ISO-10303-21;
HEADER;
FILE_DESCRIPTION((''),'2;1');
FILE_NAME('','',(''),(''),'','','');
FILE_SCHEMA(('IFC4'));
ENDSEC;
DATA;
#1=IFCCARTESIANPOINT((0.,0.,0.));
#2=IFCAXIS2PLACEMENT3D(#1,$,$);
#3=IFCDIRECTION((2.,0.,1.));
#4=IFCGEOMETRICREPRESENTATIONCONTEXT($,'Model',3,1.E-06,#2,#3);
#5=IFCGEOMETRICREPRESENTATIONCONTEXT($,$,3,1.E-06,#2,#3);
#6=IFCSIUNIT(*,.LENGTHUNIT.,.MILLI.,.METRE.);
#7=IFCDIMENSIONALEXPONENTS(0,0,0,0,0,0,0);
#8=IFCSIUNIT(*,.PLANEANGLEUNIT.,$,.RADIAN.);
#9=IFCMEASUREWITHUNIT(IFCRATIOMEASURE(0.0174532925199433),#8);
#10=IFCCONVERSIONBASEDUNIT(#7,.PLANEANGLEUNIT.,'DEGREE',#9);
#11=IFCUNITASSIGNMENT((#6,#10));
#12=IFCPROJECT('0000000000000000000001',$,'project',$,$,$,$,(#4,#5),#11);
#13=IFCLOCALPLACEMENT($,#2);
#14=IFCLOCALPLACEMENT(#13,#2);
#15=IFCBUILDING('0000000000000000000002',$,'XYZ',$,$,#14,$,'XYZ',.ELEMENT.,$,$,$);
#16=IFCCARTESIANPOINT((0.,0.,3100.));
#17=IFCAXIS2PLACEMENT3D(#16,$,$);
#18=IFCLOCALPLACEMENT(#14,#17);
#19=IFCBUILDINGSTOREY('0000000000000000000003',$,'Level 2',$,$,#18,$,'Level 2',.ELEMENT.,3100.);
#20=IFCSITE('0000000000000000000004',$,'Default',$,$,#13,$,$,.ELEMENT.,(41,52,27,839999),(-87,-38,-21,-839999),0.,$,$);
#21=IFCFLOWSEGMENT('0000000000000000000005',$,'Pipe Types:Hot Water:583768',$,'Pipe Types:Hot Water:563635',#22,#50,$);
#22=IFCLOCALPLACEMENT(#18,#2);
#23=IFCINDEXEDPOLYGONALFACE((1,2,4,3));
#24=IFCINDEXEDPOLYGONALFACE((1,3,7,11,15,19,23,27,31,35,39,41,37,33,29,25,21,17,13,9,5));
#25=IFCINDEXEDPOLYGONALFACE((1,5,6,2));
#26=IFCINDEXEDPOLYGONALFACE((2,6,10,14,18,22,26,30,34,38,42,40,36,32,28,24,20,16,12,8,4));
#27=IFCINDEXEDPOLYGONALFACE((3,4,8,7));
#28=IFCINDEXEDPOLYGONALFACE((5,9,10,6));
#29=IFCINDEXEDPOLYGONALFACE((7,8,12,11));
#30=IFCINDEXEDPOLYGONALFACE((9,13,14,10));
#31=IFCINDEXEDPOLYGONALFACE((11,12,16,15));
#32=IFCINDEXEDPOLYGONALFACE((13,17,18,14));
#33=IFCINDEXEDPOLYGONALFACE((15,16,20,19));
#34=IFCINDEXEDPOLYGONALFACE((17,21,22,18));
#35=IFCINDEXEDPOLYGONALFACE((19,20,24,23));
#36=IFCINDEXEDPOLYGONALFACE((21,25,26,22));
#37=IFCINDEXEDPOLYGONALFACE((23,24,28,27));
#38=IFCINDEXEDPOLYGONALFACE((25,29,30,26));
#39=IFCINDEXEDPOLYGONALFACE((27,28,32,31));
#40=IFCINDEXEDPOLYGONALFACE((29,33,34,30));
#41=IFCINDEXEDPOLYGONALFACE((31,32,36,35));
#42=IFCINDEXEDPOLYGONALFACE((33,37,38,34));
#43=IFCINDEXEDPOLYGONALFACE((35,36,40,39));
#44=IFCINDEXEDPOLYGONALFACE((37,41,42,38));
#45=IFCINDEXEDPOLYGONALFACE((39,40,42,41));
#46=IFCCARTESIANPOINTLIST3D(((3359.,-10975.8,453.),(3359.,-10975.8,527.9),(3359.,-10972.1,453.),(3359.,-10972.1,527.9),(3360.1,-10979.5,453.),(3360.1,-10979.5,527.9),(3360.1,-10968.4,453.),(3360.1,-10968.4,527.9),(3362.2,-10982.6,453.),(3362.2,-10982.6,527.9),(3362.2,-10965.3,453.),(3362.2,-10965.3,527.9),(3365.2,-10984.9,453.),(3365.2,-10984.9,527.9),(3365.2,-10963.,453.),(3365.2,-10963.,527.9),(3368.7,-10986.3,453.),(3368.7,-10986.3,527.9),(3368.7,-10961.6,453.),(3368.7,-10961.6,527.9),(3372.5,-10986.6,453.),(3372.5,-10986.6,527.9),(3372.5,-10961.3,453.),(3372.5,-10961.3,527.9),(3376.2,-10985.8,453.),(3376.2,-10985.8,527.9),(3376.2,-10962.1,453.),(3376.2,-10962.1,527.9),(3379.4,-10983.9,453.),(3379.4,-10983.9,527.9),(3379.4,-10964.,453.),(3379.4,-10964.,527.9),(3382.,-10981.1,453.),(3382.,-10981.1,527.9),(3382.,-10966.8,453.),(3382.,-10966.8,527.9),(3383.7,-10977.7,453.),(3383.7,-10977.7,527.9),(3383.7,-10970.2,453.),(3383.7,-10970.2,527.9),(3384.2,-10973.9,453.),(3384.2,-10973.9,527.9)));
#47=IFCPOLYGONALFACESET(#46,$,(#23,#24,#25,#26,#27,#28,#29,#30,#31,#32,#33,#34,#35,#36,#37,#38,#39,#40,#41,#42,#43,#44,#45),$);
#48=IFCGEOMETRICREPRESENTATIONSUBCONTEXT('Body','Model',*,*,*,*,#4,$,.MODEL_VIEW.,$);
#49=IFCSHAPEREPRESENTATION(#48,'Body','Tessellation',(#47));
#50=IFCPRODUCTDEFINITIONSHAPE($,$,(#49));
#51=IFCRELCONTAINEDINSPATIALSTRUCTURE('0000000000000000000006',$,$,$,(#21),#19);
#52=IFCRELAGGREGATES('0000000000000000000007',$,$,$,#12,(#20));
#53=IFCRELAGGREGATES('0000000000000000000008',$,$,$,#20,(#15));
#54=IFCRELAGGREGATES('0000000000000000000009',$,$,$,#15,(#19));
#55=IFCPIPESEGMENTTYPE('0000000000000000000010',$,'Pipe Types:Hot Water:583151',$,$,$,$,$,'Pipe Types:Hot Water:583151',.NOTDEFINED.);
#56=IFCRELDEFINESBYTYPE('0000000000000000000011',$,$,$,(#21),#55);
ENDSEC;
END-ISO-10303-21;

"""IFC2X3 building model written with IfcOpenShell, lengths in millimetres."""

from ifc_helpers import new_model, entity, si_unit, converted_unit, direction, frame, origin, origin_2d_with_axis, place, context, subcontext, project, spatial, circle, extrude, type_object, element, save


model = new_model("IFC2X3")

# Units and contexts
model_context = context("Model", 3, precision=1e-06, world=origin(), true_north=direction((2.0, 0.0, 1.0)))
context_of_model = context(None, 3, precision=1e-06, world=origin(), true_north=direction((2.0, 0.0, 1.0)))
body_context = subcontext(model_context, "Body", "Model", "MODEL_VIEW")
ifc_project = project(units=[si_unit("LENGTHUNIT", "METRE", prefix="MILLI"), converted_unit("PLANEANGLEUNIT", "DEGREE", entity("IfcRatioMeasure", 0.0174532925199433), si_unit("PLANEANGLEUNIT", "RADIAN"), dimensions=[0, 0, 0, 0, 0, 0, 0])], contexts=[model_context, context_of_model])

# Site, building, storey
site_placement = place(None, origin())
site = spatial("IfcSite", under=ifc_project, at=site_placement, Name="Default", CompositionType="ELEMENT", RefLatitude=(41, 52, 27, 839999), RefLongitude=(-87, -38, -21, -839999), RefElevation=0.0)
building_placement = place(site_placement, origin())
building = spatial("IfcBuilding", under=site, at=building_placement, Name="XYZ", LongName="XYZ", CompositionType="ELEMENT")
storey_placement = place(building_placement, frame((0.0, 0.0, 3100.0)))
storey = spatial("IfcBuildingStorey", under=building, at=storey_placement, Name="Level 2", LongName="Level 2", CompositionType="ELEMENT", Elevation=3100.0)

# Flow segment
pipe_segment_type_1 = type_object("IfcPipeSegmentType", Name="Pipe Types:Hot Water:583151", ElementType="Pipe Types:Hot Water:583151", PredefinedType="NOTDEFINED")
flow_segment_1_placement = place(storey_placement, origin())
element("IfcFlowSegment", 1, at=flow_segment_1_placement, inside=storey, type_object=pipe_segment_type_1, Name="Pipe Types:Hot Water:583768", ObjectType="Pipe Types:Hot Water:563635", context=body_context, shape_type="SweptSolid", body=[
    extrude(circle(Radius=12.7, at=origin_2d_with_axis()), frame((3371.5, -10973.9, 453.0)), (0.0, 0.0, 1.0), 74.9),
])

save(model, "model.ifc")
